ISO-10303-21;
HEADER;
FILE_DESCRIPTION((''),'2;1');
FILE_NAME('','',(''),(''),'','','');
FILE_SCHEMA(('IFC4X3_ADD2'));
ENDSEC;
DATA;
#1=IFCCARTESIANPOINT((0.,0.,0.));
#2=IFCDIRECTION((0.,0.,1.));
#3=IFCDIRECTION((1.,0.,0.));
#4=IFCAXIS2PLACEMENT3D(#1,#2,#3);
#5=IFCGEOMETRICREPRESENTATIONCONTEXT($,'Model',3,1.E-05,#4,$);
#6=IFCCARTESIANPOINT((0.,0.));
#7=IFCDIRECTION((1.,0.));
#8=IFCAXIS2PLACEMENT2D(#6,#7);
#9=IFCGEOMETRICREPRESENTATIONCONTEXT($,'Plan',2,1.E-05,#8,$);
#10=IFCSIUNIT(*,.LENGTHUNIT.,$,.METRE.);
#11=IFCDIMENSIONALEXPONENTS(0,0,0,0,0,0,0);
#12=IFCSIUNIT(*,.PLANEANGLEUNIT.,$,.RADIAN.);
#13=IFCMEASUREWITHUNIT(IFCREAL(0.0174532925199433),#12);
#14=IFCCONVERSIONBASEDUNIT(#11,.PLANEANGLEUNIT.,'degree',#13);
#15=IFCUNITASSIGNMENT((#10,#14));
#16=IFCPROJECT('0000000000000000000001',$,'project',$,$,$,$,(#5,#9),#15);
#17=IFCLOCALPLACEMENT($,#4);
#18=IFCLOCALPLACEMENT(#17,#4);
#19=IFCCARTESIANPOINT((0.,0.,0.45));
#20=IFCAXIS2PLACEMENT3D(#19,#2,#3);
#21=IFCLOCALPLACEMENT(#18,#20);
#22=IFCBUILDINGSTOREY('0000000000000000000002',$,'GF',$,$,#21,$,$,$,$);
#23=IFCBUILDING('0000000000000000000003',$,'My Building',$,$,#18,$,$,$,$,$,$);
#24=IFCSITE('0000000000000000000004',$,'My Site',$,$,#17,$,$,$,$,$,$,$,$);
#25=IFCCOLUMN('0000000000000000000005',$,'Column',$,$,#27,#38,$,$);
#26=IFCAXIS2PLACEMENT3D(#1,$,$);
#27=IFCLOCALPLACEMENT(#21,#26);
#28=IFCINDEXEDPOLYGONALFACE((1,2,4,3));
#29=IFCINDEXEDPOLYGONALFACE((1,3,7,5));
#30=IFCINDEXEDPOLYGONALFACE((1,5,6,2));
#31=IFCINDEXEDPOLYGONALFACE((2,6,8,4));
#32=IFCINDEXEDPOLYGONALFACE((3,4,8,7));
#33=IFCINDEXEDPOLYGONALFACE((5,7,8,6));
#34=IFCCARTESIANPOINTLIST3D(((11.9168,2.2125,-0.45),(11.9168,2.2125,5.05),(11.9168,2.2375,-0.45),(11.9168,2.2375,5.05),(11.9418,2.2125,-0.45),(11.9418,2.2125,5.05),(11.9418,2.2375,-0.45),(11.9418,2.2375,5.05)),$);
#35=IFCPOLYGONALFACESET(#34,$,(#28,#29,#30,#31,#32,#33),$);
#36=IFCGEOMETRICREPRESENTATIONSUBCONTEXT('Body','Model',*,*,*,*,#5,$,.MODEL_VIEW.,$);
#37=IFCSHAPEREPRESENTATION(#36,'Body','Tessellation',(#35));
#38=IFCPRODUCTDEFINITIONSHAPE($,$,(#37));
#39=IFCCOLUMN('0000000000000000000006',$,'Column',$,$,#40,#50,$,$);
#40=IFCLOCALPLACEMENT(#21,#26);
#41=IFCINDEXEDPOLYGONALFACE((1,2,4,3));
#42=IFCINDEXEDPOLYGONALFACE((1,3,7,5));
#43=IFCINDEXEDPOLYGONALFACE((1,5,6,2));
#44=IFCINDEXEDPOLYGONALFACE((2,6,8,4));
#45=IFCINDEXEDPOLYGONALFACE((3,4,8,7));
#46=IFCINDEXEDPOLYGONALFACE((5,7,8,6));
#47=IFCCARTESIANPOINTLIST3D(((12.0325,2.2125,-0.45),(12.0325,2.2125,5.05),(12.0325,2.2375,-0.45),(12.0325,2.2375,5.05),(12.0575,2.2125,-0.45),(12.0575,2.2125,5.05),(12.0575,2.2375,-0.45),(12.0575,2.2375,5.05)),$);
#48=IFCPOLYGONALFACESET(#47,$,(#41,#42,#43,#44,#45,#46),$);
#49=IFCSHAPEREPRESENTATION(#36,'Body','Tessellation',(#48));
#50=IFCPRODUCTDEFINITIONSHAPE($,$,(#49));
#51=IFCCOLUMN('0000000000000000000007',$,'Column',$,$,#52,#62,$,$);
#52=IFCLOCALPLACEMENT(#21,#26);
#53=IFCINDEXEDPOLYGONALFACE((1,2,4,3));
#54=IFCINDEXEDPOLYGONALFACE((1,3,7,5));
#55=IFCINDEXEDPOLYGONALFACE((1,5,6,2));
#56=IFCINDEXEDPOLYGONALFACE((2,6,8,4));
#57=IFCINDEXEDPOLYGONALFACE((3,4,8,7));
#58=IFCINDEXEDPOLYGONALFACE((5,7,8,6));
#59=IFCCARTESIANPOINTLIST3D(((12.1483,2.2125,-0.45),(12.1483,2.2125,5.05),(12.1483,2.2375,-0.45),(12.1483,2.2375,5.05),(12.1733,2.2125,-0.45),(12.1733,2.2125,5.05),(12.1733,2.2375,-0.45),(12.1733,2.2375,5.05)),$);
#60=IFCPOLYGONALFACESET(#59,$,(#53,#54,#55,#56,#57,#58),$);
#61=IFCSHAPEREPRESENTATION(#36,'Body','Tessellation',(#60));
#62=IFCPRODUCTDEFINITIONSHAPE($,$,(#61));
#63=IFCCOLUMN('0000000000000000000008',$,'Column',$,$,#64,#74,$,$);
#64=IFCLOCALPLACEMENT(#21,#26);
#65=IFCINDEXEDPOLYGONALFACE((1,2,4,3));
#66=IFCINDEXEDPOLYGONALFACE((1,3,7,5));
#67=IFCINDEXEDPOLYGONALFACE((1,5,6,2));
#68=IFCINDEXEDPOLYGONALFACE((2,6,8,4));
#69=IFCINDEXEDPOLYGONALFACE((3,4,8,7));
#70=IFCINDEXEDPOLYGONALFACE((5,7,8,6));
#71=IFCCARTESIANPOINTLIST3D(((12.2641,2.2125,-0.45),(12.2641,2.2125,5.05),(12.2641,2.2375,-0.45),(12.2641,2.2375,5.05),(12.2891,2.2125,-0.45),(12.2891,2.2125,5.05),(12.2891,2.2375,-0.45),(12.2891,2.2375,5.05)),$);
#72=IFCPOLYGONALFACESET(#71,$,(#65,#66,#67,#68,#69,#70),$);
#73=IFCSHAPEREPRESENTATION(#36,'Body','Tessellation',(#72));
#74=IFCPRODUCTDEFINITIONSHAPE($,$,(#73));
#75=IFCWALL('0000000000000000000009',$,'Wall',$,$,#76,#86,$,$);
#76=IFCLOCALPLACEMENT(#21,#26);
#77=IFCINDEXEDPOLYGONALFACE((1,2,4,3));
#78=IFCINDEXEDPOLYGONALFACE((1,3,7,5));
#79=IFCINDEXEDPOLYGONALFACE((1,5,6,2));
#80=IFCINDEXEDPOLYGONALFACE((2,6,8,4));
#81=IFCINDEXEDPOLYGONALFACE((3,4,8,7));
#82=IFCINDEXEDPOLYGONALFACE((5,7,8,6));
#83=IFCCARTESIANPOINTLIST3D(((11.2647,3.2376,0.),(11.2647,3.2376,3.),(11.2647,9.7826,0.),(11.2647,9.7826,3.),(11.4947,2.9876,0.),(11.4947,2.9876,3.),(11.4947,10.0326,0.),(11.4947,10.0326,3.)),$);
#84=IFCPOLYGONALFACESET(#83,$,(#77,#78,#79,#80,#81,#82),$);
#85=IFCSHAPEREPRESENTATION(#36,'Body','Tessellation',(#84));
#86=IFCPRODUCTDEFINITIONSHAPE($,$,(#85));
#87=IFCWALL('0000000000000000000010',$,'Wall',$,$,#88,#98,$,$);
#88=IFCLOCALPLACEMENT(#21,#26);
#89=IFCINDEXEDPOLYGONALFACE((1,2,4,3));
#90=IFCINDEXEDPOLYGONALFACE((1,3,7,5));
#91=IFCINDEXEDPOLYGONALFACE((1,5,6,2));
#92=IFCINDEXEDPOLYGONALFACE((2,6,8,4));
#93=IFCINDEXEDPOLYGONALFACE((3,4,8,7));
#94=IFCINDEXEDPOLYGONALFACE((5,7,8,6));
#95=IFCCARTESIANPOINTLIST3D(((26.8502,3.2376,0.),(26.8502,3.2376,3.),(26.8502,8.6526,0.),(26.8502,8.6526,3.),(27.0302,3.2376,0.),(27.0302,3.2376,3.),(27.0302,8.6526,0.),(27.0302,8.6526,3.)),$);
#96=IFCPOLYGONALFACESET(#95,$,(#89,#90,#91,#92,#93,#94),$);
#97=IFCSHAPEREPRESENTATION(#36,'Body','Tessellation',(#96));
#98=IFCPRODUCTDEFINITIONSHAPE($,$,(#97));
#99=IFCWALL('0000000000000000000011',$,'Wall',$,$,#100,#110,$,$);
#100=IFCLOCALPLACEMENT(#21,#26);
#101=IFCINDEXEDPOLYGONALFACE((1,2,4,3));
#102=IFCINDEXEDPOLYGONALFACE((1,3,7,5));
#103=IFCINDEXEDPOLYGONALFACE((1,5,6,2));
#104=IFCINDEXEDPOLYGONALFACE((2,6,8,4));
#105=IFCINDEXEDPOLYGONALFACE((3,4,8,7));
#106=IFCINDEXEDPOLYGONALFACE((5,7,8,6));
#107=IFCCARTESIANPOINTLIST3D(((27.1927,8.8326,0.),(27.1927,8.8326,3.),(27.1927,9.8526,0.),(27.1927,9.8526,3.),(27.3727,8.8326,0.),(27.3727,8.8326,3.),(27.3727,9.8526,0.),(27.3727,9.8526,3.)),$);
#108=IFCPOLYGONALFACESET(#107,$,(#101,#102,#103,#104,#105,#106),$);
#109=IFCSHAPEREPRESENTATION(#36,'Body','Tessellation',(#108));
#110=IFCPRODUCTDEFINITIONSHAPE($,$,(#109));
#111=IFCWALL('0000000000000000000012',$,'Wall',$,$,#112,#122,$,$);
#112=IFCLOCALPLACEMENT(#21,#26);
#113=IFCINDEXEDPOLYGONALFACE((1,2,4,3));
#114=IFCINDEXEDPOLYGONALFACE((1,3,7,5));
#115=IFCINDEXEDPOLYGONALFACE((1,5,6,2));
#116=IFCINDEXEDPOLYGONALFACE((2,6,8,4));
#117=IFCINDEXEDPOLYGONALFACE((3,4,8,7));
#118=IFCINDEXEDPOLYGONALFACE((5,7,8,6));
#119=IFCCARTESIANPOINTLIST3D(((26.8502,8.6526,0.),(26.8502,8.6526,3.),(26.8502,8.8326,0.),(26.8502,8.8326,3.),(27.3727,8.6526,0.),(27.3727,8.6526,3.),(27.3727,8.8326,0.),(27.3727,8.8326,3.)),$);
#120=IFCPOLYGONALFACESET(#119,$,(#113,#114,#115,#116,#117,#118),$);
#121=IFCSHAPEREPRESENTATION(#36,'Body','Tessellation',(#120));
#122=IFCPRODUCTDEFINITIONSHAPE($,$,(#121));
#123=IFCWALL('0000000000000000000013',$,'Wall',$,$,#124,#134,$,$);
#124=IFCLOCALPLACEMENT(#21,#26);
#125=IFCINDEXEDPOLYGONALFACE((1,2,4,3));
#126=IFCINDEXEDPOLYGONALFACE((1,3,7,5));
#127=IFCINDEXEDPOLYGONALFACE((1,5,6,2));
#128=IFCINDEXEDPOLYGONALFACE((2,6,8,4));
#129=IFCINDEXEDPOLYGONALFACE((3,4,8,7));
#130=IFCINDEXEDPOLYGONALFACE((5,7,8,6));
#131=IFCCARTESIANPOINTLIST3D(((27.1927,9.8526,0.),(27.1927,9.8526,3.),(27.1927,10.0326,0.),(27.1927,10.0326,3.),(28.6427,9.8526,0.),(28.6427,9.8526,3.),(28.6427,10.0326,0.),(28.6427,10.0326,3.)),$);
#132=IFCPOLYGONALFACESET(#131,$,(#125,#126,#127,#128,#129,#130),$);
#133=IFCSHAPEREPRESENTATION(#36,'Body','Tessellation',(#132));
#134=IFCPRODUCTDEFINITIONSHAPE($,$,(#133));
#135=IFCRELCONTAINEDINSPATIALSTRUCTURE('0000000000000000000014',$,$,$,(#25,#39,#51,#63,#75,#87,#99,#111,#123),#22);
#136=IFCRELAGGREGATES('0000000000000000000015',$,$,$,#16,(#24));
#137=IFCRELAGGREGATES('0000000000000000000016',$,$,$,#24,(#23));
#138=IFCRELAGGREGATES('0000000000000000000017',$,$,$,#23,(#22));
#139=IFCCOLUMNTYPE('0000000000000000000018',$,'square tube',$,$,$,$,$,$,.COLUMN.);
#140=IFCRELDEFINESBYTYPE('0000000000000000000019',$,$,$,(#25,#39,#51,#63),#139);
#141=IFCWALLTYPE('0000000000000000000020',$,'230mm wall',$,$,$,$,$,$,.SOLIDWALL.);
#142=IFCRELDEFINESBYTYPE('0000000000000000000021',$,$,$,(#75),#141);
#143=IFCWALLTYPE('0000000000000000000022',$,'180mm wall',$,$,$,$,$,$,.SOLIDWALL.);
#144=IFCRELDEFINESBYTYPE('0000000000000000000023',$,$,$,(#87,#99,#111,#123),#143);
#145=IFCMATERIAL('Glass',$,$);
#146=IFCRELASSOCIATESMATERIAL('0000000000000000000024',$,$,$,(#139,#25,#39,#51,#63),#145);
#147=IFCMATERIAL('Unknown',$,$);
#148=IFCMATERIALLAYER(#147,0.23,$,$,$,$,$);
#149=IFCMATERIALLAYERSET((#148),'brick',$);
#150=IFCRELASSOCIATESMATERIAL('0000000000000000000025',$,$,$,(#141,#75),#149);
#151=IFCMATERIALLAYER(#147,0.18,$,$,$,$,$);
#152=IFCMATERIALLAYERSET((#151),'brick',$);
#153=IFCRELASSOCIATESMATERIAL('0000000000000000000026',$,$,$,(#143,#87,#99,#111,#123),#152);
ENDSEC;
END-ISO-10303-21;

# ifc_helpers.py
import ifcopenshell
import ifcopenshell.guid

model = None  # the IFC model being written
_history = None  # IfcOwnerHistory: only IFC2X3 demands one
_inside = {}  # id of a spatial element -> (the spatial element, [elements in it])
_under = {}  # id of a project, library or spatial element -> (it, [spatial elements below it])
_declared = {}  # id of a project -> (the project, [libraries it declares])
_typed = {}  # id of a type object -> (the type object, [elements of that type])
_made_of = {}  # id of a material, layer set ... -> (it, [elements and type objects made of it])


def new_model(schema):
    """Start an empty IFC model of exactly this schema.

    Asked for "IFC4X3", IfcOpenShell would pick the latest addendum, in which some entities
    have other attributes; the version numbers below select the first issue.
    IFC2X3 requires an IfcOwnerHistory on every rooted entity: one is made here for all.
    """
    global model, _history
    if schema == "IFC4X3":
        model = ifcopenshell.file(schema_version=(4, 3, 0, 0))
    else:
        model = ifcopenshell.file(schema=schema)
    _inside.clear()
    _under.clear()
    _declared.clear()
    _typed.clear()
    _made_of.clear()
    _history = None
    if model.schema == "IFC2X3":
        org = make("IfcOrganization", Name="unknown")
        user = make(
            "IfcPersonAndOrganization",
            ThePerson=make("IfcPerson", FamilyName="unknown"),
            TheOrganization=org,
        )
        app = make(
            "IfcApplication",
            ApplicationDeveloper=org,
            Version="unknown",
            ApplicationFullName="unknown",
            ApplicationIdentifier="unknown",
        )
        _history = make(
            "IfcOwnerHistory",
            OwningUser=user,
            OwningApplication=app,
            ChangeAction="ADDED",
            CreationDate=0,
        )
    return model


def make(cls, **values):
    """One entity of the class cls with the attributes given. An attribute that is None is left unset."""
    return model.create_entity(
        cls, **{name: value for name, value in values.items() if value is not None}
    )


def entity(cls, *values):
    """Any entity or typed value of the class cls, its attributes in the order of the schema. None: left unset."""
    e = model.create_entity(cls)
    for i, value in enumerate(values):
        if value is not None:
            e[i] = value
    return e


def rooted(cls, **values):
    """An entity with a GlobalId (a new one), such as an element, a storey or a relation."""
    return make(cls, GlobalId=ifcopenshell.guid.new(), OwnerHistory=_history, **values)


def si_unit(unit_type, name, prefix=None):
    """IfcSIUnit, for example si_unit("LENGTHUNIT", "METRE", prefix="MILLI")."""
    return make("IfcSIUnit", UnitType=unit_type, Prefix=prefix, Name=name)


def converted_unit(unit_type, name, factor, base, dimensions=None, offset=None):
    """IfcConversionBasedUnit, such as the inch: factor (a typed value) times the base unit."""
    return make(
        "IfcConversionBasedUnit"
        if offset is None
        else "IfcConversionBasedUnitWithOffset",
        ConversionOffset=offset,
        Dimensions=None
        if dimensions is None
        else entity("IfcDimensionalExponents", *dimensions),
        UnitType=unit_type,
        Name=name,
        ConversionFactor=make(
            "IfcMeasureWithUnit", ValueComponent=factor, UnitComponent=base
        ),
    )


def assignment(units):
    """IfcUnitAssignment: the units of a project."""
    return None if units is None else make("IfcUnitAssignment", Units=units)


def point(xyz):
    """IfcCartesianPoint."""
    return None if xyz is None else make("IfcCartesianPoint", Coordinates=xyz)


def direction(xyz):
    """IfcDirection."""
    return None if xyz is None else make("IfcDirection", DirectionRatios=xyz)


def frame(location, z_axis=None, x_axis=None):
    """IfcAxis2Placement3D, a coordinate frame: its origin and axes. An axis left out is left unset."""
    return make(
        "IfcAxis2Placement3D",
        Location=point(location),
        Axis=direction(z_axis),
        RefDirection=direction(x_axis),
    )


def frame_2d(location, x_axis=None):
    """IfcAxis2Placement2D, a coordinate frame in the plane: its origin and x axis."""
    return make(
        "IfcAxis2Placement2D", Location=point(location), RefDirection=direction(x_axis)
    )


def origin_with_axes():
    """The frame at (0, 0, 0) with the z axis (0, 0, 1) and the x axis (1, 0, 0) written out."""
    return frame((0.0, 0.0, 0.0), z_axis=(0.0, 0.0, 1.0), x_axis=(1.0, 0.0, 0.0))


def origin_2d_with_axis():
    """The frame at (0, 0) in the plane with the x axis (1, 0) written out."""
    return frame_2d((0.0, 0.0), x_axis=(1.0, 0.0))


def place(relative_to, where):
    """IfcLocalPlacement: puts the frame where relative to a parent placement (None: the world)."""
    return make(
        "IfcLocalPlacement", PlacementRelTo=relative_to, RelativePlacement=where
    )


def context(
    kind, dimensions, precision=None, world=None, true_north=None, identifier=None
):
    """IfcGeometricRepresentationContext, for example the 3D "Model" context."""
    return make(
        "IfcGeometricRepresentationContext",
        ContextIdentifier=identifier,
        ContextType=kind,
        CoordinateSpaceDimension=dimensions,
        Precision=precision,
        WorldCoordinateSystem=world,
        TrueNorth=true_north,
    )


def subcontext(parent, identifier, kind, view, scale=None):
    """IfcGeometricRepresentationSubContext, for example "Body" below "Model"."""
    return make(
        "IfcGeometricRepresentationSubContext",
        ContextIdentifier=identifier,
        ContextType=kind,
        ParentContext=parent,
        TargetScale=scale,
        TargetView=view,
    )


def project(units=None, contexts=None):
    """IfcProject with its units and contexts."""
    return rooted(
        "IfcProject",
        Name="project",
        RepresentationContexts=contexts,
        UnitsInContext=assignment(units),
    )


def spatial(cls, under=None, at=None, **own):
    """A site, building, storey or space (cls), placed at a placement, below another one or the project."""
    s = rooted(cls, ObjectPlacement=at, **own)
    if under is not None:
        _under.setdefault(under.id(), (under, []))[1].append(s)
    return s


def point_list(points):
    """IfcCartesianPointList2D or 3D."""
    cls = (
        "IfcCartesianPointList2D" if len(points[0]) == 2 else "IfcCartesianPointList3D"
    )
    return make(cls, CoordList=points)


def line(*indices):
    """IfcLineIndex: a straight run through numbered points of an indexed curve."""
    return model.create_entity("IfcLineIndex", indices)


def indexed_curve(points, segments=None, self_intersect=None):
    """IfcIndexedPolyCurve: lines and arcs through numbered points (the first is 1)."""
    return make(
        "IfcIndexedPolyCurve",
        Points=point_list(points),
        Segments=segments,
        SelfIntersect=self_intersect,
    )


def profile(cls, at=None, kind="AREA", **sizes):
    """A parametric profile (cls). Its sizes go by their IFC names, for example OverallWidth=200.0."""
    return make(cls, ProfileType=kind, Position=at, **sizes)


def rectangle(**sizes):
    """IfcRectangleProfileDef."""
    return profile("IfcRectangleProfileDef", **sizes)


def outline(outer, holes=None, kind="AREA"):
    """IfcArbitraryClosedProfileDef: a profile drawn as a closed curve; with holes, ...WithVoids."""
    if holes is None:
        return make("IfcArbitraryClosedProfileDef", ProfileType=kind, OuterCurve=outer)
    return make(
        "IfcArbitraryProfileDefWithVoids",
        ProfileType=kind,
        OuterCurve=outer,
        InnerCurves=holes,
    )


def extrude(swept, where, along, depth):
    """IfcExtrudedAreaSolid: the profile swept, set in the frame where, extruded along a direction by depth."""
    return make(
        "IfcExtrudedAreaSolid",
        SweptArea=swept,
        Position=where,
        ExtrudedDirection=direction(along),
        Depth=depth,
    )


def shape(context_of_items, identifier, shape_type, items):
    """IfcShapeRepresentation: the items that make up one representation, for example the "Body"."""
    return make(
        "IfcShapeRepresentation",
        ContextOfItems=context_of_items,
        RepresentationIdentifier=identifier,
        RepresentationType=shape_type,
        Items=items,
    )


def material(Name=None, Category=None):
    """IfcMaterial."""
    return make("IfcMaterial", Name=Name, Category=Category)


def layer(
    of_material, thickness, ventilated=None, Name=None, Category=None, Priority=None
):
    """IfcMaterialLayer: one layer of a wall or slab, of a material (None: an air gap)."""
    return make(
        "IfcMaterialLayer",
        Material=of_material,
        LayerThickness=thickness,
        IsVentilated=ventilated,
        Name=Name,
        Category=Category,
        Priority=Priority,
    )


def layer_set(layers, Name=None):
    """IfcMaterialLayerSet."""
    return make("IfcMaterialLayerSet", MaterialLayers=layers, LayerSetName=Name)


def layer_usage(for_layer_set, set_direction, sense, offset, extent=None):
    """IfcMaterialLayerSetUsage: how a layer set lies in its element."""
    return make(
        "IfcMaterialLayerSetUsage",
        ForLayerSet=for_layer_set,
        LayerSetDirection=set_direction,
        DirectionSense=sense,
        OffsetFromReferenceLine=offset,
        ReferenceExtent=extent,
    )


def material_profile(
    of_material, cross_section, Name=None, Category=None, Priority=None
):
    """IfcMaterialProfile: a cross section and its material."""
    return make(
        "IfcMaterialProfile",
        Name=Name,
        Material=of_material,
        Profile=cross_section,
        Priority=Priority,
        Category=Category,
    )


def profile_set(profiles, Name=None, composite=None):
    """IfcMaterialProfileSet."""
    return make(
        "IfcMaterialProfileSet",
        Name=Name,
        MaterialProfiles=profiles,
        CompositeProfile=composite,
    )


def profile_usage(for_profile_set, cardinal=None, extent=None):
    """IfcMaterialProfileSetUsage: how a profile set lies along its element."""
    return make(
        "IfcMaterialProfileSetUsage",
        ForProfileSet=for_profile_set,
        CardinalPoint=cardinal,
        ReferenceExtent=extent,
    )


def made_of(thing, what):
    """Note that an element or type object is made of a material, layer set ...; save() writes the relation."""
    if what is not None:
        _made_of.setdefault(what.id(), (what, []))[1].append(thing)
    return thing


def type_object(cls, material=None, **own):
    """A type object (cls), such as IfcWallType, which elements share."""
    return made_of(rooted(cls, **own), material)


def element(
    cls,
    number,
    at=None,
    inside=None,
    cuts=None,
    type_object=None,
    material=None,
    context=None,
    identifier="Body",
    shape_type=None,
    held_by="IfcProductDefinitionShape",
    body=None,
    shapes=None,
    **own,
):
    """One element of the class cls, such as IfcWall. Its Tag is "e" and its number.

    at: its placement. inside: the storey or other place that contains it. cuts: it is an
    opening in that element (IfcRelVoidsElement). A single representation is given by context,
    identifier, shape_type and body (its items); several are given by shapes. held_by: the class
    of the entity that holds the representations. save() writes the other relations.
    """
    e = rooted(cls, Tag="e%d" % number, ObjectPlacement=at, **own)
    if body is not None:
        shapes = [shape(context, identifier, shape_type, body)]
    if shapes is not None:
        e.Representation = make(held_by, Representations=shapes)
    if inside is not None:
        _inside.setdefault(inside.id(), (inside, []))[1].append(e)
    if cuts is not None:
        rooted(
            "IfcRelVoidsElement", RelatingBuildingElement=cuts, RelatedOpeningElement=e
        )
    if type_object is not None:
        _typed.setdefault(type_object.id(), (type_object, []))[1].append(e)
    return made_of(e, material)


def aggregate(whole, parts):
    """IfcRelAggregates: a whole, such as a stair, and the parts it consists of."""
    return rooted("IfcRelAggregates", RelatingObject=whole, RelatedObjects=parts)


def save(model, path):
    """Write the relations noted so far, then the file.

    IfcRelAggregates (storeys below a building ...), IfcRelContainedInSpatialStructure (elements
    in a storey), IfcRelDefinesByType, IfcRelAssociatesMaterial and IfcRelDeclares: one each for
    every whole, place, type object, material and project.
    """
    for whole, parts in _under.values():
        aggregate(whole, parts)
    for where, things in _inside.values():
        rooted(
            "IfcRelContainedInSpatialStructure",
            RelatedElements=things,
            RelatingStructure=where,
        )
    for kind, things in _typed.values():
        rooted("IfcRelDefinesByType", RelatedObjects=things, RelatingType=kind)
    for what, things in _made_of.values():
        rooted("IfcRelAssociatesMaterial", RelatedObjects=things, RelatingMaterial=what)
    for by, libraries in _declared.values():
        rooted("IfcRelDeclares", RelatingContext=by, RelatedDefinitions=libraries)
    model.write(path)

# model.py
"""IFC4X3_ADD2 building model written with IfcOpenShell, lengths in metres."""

from ifc_helpers import new_model, entity, si_unit, converted_unit, frame, origin_with_axes, origin_2d_with_axis, place, context, subcontext, project, spatial, line, indexed_curve, rectangle, outline, extrude, material, layer, layer_set, layer_usage, material_profile, profile_set, profile_usage, type_object, element, save


model = new_model("IFC4X3_ADD2")

# Units and contexts
model_context = context("Model", 3, precision=1e-05, world=origin_with_axes())
plan_context = context("Plan", 2, precision=1e-05, world=origin_2d_with_axis())
body_context = subcontext(model_context, "Body", "Model", "MODEL_VIEW")
ifc_project = project(units=[si_unit("LENGTHUNIT", "METRE"), converted_unit("PLANEANGLEUNIT", "degree", entity("IfcReal", 0.0174532925199433), si_unit("PLANEANGLEUNIT", "RADIAN"), dimensions=[0, 0, 0, 0, 0, 0, 0])], contexts=[model_context, plan_context])

# Site, building, storey
site_placement = place(None, origin_with_axes())
site = spatial("IfcSite", under=ifc_project, at=site_placement, Name="My Site")
building_placement = place(site_placement, origin_with_axes())
building = spatial("IfcBuilding", under=site, at=building_placement, Name="My Building")
storey_placement = place(building_placement, frame((0.0, 0.0, 0.45), z_axis=(0.0, 0.0, 1.0), x_axis=(1.0, 0.0, 0.0)))
storey = spatial("IfcBuildingStorey", under=building, at=storey_placement, Name="GF")

# Columns
ifc_material_1 = material(Name="Glass")
ifc_material_profile = material_profile(ifc_material_1, rectangle(XDim=0.025, YDim=0.025))
ifc_profile_set = profile_set([ifc_material_profile])
column_type = type_object("IfcColumnType", Name="square tube", PredefinedType="COLUMN", material=ifc_profile_set)
ifc_profile_usage_1 = profile_usage(ifc_profile_set, cardinal=5)
column_1_placement = place(storey_placement, frame((11.9293, 2.225, -0.45), z_axis=(0.0, 0.0, 1.0), x_axis=(1.0, 0.0, 0.0)))
element("IfcColumn", 1, at=column_1_placement, inside=storey, type_object=column_type, material=ifc_profile_usage_1, Name="Column", context=body_context, shape_type="SweptSolid", body=[
    extrude(rectangle(XDim=0.025, YDim=0.025), origin_with_axes(), (0.0, 0.0, 1.0), 5.5),
])
ifc_profile_usage_2 = profile_usage(ifc_profile_set, cardinal=5)
column_2_placement = place(storey_placement, frame((12.045, 2.225, -0.45), z_axis=(0.0, 0.0, 1.0), x_axis=(1.0, 0.0, 0.0)))
element("IfcColumn", 2, at=column_2_placement, inside=storey, type_object=column_type, material=ifc_profile_usage_2, Name="Column", context=body_context, shape_type="SweptSolid", body=[
    extrude(rectangle(XDim=0.025, YDim=0.025), origin_with_axes(), (0.0, 0.0, 1.0), 5.5),
])
ifc_profile_usage_3 = profile_usage(ifc_profile_set, cardinal=5)
column_3_placement = place(storey_placement, frame((12.1608, 2.225, -0.45), z_axis=(0.0, 0.0, 1.0), x_axis=(1.0, 0.0, 0.0)))
element("IfcColumn", 3, at=column_3_placement, inside=storey, type_object=column_type, material=ifc_profile_usage_3, Name="Column", context=body_context, shape_type="SweptSolid", body=[
    extrude(rectangle(XDim=0.025, YDim=0.025), origin_with_axes(), (0.0, 0.0, 1.0), 5.5),
])
ifc_profile_usage_4 = profile_usage(ifc_profile_set, cardinal=5)
column_4_placement = place(storey_placement, frame((12.2766, 2.225, -0.45), z_axis=(0.0, 0.0, 1.0), x_axis=(1.0, 0.0, 0.0)))
element("IfcColumn", 4, at=column_4_placement, inside=storey, type_object=column_type, material=ifc_profile_usage_4, Name="Column", context=body_context, shape_type="SweptSolid", body=[
    extrude(rectangle(XDim=0.025, YDim=0.025), origin_with_axes(), (0.0, 0.0, 1.0), 5.5),
])

# Walls
ifc_material_2 = material(Name="Unknown")
ifc_layer_1 = layer(ifc_material_2, 0.23)
ifc_layer_set_1 = layer_set([ifc_layer_1], Name="brick")
ifc_layer_usage_1 = layer_usage(ifc_layer_set_1, "AXIS2", "POSITIVE", 0.0)
wall_type_1 = type_object("IfcWallType", Name="230mm wall", PredefinedType="SOLIDWALL", material=ifc_layer_set_1)
wall_1_placement = place(storey_placement, frame((11.4947, 2.9876, 0.0), z_axis=(0.0, 0.0, 1.0), x_axis=(0.0, 1.0, 0.0)))
element("IfcWall", 5, at=wall_1_placement, inside=storey, type_object=wall_type_1, material=ifc_layer_usage_1, Name="Wall", context=body_context, shape_type="SweptSolid", body=[
    extrude(outline(indexed_curve([(0.0, 0.0), (0.25, 0.23), (6.795, 0.23), (7.045, 0.0)], segments=[line(1, 2, 3, 4, 1)])), origin_with_axes(), (0.0, 0.0, 1.0), 3.0),
])
ifc_layer_2 = layer(ifc_material_2, 0.18)
ifc_layer_set_2 = layer_set([ifc_layer_2], Name="brick")
ifc_layer_usage_2 = layer_usage(ifc_layer_set_2, "AXIS2", "POSITIVE", 0.0)
wall_type_2 = type_object("IfcWallType", Name="180mm wall", PredefinedType="SOLIDWALL", material=ifc_layer_set_2)
wall_2_placement = place(storey_placement, frame((27.0302, 3.2376, 0.0), z_axis=(0.0, 0.0, 1.0), x_axis=(0.0, 1.0, 0.0)))
element("IfcWall", 6, at=wall_2_placement, inside=storey, type_object=wall_type_2, material=ifc_layer_usage_2, Name="Wall", context=body_context, shape_type="SweptSolid", body=[
    extrude(outline(indexed_curve([(0.0, 0.0), (0.0, 0.18), (5.415, 0.18), (5.415, 0.0), (0.0, 0.0)], self_intersect=False)), origin_with_axes(), (0.0, 0.0, 1.0), 3.0),
])
ifc_layer_usage_3 = layer_usage(ifc_layer_set_2, "AXIS2", "POSITIVE", 0.0)
wall_3_placement = place(storey_placement, frame((27.3727, 8.8326, 0.0), z_axis=(0.0, 0.0, 1.0), x_axis=(0.0, 1.0, 0.0)))
element("IfcWall", 7, at=wall_3_placement, inside=storey, type_object=wall_type_2, material=ifc_layer_usage_3, Name="Wall", context=body_context, shape_type="SweptSolid", body=[
    extrude(outline(indexed_curve([(0.0, 0.0), (0.0, 0.18), (1.02, 0.18), (1.02, 0.0), (0.0, 0.0)], self_intersect=False)), origin_with_axes(), (0.0, 0.0, 1.0), 3.0),
])
ifc_layer_usage_4 = layer_usage(ifc_layer_set_2, "AXIS2", "POSITIVE", 0.0)
wall_4_placement = place(storey_placement, frame((27.3727, 8.8326, 0.0), z_axis=(0.0, 0.0, 1.0), x_axis=(-1.0, 0.0, 0.0)))
element("IfcWall", 8, at=wall_4_placement, inside=storey, type_object=wall_type_2, material=ifc_layer_usage_4, Name="Wall", context=body_context, shape_type="SweptSolid", body=[
    extrude(outline(indexed_curve([(0.0, 0.0), (0.0, 0.18), (0.5225, 0.18), (0.5225, 0.0), (0.0, 0.0)], self_intersect=False)), origin_with_axes(), (0.0, 0.0, 1.0), 3.0),
])
ifc_layer_usage_5 = layer_usage(ifc_layer_set_2, "AXIS2", "POSITIVE", 0.0)
wall_5_placement = place(storey_placement, frame((28.6427, 10.0326, 0.0), z_axis=(0.0, 0.0, 1.0), x_axis=(-1.0, 0.0, 0.0)))
element("IfcWall", 9, at=wall_5_placement, inside=storey, type_object=wall_type_2, material=ifc_layer_usage_5, Name="Wall", context=body_context, shape_type="SweptSolid", body=[
    extrude(outline(indexed_curve([(0.0, 0.0), (0.0, 0.18), (1.45, 0.18), (1.45, 0.0), (0.0, 0.0)], self_intersect=False)), origin_with_axes(), (0.0, 0.0, 1.0), 3.0),
])

save(model, "model.ifc")
